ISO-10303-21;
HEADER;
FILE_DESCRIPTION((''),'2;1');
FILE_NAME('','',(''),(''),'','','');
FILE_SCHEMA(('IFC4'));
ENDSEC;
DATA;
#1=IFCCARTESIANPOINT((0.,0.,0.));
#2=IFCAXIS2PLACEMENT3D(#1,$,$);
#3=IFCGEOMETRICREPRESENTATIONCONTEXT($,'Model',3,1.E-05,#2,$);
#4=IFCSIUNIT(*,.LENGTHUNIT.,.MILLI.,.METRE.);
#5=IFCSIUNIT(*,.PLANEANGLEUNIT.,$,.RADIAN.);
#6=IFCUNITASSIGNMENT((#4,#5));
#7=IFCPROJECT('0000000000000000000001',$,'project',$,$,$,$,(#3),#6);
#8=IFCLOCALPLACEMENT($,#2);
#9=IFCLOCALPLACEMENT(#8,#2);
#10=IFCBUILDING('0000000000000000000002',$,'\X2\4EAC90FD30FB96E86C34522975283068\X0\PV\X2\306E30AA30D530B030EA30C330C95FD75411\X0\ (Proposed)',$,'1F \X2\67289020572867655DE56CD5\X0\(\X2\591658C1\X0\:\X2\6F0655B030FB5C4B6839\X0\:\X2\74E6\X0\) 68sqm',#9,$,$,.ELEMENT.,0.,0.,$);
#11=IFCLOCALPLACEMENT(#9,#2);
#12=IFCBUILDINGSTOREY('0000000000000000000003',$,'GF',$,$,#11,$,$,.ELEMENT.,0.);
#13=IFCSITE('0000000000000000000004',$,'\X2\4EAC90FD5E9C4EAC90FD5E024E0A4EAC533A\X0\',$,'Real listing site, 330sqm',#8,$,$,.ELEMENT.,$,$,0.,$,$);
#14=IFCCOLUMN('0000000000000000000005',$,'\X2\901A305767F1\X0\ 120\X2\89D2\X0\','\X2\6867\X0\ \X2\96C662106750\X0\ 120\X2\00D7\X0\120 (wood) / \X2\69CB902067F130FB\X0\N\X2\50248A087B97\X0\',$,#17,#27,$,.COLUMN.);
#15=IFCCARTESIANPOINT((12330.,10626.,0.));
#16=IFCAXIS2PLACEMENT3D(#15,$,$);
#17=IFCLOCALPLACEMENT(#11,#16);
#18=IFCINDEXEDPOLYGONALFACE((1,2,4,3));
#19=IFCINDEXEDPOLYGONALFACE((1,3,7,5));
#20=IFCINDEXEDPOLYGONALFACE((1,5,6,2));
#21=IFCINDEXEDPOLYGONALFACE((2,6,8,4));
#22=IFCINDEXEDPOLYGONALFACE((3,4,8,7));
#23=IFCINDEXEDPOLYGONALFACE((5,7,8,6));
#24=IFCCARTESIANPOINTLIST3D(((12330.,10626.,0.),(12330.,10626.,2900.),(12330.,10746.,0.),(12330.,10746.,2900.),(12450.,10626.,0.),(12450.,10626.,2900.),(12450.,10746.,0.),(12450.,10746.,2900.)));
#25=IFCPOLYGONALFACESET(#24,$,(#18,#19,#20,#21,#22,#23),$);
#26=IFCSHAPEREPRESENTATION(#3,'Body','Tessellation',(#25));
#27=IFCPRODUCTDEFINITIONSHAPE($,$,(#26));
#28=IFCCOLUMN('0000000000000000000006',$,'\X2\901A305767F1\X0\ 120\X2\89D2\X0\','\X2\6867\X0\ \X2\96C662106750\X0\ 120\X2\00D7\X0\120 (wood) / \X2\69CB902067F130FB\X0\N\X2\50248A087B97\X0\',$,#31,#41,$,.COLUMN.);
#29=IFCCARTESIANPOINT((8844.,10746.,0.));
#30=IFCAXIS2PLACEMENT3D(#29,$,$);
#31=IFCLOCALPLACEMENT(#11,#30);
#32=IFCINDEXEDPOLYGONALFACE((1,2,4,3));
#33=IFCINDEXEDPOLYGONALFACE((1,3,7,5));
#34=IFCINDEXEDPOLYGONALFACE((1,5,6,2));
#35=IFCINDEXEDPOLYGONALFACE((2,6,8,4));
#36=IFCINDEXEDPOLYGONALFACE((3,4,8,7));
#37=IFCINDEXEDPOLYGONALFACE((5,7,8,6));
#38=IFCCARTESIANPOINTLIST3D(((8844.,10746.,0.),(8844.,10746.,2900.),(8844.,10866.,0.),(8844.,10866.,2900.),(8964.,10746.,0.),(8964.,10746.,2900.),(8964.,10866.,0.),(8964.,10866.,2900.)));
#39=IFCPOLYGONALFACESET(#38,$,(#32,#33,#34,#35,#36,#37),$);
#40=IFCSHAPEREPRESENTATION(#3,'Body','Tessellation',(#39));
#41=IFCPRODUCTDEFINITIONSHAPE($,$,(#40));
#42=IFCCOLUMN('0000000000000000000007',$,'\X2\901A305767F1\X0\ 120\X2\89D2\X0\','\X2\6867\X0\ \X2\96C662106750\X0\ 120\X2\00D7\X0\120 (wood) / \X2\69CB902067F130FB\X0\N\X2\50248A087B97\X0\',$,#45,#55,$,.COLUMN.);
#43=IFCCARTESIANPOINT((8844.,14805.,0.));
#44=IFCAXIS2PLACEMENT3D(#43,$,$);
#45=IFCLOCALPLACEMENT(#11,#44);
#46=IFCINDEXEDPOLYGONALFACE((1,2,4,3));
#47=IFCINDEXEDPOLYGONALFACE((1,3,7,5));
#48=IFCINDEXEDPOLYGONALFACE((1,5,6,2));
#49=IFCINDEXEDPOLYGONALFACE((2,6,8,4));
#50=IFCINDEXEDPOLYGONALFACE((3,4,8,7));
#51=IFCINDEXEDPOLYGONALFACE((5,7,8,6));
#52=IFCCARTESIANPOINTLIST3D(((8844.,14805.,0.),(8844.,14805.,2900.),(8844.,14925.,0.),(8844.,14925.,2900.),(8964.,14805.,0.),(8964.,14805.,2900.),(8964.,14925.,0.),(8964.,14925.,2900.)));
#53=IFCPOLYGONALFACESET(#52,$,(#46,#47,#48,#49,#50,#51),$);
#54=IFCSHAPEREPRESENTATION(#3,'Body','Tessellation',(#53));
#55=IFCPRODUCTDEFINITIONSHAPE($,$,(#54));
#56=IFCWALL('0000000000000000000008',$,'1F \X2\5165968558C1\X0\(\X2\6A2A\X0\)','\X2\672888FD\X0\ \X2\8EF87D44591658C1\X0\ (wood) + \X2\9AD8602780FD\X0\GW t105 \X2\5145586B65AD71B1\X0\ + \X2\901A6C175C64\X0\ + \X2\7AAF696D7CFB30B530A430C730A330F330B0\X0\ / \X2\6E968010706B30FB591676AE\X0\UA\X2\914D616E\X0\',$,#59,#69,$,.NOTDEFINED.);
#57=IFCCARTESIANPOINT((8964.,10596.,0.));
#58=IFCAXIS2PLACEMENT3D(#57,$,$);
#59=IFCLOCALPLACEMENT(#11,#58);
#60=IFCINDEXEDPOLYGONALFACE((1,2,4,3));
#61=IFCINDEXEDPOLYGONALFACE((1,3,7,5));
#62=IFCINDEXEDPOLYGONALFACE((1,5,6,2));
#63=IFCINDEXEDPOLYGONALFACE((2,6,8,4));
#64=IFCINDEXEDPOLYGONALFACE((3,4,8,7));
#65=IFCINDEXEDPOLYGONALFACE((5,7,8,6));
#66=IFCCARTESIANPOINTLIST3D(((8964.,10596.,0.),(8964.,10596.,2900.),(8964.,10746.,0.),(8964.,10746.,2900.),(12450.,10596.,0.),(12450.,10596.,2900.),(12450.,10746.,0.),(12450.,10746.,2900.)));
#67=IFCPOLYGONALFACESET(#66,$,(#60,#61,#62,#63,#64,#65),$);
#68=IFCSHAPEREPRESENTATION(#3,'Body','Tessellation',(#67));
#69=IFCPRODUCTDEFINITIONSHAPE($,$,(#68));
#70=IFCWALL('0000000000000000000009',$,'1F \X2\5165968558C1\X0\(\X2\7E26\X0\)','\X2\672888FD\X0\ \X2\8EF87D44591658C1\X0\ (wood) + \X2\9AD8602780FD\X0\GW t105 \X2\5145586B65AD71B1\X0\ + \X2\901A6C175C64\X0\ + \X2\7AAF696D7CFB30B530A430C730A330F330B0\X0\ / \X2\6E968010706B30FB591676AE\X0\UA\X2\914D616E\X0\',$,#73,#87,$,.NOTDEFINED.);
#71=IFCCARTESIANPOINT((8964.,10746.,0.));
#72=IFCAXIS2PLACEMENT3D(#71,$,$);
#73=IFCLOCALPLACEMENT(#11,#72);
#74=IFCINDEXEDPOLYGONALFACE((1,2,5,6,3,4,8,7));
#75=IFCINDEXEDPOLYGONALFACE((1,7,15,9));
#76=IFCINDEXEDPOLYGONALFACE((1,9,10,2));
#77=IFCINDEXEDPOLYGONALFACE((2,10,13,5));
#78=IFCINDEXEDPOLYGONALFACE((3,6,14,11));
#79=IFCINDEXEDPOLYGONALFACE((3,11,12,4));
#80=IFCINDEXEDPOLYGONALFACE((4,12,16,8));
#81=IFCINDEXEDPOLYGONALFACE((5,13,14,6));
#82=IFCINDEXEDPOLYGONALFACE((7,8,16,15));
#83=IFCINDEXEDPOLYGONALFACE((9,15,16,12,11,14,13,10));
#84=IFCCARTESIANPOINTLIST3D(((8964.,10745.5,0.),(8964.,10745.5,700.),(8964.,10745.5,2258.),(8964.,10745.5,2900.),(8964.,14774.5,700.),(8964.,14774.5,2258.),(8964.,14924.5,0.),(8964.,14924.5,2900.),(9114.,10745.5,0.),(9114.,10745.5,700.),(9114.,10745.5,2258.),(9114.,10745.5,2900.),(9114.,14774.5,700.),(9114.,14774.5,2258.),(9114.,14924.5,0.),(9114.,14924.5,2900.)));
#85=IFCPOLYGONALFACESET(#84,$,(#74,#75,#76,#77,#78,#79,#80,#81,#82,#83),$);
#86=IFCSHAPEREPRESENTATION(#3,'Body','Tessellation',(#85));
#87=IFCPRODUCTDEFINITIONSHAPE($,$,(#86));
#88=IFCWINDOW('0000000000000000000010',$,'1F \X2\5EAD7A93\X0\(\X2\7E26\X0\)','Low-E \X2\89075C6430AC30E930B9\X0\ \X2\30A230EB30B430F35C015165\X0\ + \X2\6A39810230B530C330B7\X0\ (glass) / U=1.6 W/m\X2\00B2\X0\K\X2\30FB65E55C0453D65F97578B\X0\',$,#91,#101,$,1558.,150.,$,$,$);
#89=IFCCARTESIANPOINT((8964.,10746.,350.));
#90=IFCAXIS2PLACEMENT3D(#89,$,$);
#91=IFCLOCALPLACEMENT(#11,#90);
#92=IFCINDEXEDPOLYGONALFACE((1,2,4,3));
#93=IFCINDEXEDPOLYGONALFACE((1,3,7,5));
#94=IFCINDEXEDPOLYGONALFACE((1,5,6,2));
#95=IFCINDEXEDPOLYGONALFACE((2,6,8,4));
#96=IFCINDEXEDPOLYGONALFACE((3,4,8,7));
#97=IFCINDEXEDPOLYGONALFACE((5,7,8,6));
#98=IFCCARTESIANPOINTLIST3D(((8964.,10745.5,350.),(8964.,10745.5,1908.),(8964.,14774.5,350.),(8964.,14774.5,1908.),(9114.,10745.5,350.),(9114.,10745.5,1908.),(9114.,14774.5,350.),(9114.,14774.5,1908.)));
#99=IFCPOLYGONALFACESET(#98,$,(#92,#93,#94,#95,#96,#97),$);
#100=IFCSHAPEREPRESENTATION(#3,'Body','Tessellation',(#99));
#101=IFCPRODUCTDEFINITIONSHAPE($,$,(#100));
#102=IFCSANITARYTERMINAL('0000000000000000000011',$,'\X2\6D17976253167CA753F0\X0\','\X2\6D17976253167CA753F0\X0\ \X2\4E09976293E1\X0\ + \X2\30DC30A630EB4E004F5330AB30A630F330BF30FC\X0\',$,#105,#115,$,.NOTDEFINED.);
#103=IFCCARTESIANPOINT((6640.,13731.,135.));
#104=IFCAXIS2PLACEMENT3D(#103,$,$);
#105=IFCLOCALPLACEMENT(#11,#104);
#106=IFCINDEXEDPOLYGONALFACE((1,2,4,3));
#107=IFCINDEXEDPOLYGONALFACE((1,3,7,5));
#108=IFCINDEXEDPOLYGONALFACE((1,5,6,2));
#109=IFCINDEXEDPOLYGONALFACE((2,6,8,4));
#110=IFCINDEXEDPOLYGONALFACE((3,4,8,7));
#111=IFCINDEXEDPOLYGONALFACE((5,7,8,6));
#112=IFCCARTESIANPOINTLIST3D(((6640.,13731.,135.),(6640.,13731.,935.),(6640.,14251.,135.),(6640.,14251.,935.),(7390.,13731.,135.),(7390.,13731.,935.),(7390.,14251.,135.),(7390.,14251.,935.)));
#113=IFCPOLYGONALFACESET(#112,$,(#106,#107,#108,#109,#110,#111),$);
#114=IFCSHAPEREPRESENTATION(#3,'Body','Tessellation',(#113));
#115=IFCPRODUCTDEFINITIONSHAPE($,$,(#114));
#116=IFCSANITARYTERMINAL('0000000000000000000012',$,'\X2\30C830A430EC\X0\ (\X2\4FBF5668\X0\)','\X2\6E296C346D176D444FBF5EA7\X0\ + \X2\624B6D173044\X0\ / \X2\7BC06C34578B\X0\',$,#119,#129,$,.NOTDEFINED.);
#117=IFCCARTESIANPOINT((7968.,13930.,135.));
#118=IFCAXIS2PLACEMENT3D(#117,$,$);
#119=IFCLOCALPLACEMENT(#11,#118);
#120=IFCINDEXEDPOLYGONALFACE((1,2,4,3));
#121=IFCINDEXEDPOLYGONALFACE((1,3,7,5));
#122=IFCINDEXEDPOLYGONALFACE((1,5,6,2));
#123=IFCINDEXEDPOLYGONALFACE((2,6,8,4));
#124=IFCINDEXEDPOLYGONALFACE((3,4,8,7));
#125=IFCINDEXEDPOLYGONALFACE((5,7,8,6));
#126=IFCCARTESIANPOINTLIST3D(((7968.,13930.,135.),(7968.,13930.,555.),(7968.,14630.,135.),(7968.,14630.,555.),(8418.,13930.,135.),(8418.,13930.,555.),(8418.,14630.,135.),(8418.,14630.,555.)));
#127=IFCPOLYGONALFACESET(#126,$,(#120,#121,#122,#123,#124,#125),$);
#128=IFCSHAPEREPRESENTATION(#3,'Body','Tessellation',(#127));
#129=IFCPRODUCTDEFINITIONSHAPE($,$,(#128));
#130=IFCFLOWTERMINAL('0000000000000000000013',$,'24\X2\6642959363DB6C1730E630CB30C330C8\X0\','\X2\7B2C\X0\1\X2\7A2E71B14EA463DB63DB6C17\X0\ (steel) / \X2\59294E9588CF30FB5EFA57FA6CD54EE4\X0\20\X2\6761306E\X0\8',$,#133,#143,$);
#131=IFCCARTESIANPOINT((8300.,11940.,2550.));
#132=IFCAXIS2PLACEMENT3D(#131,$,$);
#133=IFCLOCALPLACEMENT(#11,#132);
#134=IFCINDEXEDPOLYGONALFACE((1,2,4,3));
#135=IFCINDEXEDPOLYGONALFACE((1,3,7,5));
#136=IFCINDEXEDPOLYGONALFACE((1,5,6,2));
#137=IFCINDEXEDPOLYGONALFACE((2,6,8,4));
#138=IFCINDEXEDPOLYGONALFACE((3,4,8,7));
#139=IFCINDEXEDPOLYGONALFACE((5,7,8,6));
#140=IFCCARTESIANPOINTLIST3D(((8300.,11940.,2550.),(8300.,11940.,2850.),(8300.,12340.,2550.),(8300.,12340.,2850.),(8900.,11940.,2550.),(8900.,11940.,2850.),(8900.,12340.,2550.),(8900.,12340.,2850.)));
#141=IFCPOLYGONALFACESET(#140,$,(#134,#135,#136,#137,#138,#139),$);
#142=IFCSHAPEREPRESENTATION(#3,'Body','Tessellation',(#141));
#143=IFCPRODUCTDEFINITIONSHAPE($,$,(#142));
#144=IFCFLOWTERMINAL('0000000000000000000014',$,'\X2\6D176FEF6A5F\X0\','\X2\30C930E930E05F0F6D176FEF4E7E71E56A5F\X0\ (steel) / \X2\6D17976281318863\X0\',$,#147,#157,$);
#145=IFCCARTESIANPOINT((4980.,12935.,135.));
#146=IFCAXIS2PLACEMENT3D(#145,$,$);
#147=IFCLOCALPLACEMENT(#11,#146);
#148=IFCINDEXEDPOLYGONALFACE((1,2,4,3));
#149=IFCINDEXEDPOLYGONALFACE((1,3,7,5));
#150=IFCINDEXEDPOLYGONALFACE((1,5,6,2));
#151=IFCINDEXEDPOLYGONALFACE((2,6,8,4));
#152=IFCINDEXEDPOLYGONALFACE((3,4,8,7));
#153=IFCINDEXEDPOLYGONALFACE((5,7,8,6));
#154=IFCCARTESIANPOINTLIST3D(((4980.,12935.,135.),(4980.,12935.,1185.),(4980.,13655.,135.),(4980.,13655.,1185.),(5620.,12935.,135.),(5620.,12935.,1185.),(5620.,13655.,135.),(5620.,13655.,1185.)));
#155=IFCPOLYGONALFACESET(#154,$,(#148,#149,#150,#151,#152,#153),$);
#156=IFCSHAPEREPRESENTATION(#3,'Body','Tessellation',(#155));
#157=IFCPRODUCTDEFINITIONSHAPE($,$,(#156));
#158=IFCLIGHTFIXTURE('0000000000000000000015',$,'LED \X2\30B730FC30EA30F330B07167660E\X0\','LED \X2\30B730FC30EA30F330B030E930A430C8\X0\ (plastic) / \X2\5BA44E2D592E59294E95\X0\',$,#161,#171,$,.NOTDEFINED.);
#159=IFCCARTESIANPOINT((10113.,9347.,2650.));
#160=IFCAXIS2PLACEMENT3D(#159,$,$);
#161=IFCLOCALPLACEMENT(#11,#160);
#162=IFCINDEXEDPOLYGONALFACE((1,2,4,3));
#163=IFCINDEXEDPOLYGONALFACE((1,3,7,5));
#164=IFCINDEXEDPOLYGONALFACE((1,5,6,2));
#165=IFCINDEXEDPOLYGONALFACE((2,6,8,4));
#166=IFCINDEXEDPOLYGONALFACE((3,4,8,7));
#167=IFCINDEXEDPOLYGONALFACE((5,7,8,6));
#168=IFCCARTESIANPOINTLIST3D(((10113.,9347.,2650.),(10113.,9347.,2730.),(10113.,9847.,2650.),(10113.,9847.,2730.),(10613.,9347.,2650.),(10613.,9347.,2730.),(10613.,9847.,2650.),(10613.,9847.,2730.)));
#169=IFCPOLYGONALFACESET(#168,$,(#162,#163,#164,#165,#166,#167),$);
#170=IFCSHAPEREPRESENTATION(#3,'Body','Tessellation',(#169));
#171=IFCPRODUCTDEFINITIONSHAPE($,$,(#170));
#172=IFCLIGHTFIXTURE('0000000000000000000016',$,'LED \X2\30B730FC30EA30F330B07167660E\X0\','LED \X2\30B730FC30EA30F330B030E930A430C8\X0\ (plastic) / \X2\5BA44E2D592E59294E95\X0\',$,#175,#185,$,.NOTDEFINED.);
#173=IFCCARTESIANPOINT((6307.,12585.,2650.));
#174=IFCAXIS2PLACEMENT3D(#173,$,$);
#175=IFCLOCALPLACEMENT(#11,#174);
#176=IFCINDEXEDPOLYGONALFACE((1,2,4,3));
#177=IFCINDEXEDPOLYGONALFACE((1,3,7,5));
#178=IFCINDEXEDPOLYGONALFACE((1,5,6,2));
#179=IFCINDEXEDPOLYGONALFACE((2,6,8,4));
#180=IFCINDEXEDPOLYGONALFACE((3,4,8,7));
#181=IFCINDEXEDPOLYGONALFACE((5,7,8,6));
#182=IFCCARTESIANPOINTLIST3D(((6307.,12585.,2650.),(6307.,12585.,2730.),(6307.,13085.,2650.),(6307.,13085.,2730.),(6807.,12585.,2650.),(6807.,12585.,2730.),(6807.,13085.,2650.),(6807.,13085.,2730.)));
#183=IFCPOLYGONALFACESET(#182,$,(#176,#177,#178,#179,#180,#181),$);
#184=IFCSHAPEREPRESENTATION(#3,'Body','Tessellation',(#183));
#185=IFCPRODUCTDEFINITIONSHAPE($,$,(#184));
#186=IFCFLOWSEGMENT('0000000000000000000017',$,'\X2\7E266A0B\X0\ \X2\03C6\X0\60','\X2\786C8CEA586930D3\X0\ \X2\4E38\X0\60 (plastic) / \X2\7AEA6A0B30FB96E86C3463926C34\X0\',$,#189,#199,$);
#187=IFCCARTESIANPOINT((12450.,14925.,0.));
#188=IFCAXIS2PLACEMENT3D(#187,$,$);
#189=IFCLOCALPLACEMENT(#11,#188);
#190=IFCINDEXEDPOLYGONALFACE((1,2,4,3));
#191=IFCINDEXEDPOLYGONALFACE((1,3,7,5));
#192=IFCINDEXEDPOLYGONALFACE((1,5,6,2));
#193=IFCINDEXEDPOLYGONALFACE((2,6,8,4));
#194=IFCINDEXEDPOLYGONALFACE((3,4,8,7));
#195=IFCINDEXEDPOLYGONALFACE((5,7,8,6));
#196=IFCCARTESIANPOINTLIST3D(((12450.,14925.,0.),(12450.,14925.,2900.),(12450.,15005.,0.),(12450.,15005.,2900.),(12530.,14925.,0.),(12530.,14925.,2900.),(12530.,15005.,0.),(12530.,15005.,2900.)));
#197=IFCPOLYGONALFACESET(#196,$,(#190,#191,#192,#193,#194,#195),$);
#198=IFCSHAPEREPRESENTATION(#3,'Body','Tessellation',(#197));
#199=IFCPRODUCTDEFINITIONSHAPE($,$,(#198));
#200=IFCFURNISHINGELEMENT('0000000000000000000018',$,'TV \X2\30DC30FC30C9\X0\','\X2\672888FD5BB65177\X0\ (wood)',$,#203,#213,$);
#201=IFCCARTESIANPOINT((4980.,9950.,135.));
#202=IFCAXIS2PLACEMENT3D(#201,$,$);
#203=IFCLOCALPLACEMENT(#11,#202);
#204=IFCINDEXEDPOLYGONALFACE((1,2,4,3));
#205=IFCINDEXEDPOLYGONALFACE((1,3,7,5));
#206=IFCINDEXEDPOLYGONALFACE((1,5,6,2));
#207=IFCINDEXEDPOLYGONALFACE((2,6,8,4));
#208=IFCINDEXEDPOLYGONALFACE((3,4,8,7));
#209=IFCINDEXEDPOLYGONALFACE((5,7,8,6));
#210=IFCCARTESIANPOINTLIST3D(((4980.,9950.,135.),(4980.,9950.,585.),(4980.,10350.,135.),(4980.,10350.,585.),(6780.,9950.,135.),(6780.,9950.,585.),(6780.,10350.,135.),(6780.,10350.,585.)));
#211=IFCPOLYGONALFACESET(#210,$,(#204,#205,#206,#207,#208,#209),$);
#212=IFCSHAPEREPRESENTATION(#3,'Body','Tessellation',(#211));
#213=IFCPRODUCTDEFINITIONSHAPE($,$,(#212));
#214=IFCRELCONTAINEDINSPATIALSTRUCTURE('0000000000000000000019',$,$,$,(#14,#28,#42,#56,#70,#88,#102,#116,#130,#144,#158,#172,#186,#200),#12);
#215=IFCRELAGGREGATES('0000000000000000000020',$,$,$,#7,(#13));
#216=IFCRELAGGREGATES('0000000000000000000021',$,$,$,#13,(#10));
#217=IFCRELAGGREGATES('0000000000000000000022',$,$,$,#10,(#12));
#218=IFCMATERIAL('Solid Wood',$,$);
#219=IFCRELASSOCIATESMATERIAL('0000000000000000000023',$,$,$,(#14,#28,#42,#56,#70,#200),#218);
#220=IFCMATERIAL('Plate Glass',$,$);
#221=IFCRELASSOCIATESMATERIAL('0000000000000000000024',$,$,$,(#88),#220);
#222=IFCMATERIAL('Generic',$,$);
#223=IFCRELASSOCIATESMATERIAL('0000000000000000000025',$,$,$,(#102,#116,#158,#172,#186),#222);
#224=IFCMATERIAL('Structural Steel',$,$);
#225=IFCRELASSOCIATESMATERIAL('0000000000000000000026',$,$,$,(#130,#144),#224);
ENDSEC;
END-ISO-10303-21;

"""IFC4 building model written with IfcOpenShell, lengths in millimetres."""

from ifc_helpers import new_model, si_unit, frame, frame_2d, origin, place, context, project, spatial, rectangle, extrude, material, element, fill, save


model = new_model("IFC4")

# Units and contexts
model_context = context("Model", 3, precision=1e-05, world=origin())
ifc_project = project(units=[si_unit("LENGTHUNIT", "METRE", prefix="MILLI"), si_unit("PLANEANGLEUNIT", "RADIAN")], contexts=[model_context])

# Site, building, storey
site_placement = place(None, origin())
site = spatial("IfcSite", under=ifc_project, at=site_placement, Name="京都府京都市上京区", ObjectType="Real listing site, 330sqm", CompositionType="ELEMENT", RefElevation=0.0)
building_placement = place(site_placement, origin())
building = spatial("IfcBuilding", under=site, at=building_placement, Name="京都・雨水利用とPVのオフグリッド志向 (Proposed)", ObjectType="1F 木造在来工法(外壁:漆喰・屋根:瓦) 68sqm", CompositionType="ELEMENT", ElevationOfRefHeight=0.0, ElevationOfTerrain=0.0)
storey_placement = place(building_placement, origin())
storey = spatial("IfcBuildingStorey", under=building, at=storey_placement, Name="GF", CompositionType="ELEMENT", Elevation=0.0)

# Columns
ifc_material_1 = material(Name="Solid Wood")
column_1_placement = place(storey_placement, frame((12330.0, 10626.0, 0.0)))
element("IfcColumn", 1, at=column_1_placement, inside=storey, material=ifc_material_1, Name="通し柱 120角", Description="桧 集成材 120×120 (wood) / 構造柱・N値計算", PredefinedType="COLUMN", context=model_context, shape_type="SweptSolid", body=[
    extrude(rectangle(XDim=120.0, YDim=120.0, at=frame_2d((60.0, 60.0))), frame((12330.0, 10626.0, 0.0)), (0.0, 0.0, 1.0), 2900.0),
])
column_2_placement = place(storey_placement, frame((8844.0, 10746.0, 0.0)))
element("IfcColumn", 2, at=column_2_placement, inside=storey, material=ifc_material_1, Name="通し柱 120角", Description="桧 集成材 120×120 (wood) / 構造柱・N値計算", PredefinedType="COLUMN", context=model_context, shape_type="SweptSolid", body=[
    extrude(rectangle(XDim=120.0, YDim=120.0, at=frame_2d((60.0, 60.0))), frame((8844.0, 10746.0, 0.0)), (0.0, 0.0, 1.0), 2900.0),
])
column_3_placement = place(storey_placement, frame((8844.0, 14805.0, 0.0)))
element("IfcColumn", 3, at=column_3_placement, inside=storey, material=ifc_material_1, Name="通し柱 120角", Description="桧 集成材 120×120 (wood) / 構造柱・N値計算", PredefinedType="COLUMN", context=model_context, shape_type="SweptSolid", body=[
    extrude(rectangle(XDim=120.0, YDim=120.0, at=frame_2d((60.0, 60.0))), frame((8844.0, 14805.0, 0.0)), (0.0, 0.0, 1.0), 2900.0),
])

# Wall
wall_1_placement = place(storey_placement, frame((8964.0, 10596.0, 0.0)))
element("IfcWall", 4, at=wall_1_placement, inside=storey, material=ifc_material_1, Name="1F 入隅壁(横)", Description="木製 軸組外壁 (wood) + 高性能GW t105 充填断熱 + 通気層 + 窯業系サイディング / 準耐火・外皮UA配慮", PredefinedType="NOTDEFINED", context=model_context, shape_type="SweptSolid", body=[
    extrude(rectangle(XDim=3486.0, YDim=150.0, at=frame_2d((1743.0, 75.0))), frame((8964.0, 10596.0, 0.0)), (0.0, 0.0, 1.0), 2900.0),
])

# Wall, opening, window
wall_2_placement = place(storey_placement, frame((8964.0, 10746.0, 0.0)))
wall_2 = element("IfcWall", 5, at=wall_2_placement, inside=storey, material=ifc_material_1, Name="1F 入隅壁(縦)", Description="木製 軸組外壁 (wood) + 高性能GW t105 充填断熱 + 通気層 + 窯業系サイディング / 準耐火・外皮UA配慮", PredefinedType="NOTDEFINED", context=model_context, shape_type="SweptSolid", body=[
    extrude(rectangle(XDim=150.0, YDim=4179.0, at=frame_2d((75.0, 2089.0))), frame((8964.0, 10746.0, 0.0)), (0.0, 0.0, 1.0), 2900.0),
])
opening_placement = place(storey_placement, frame((8964.0, 10746.0, 350.0)))
opening = element("IfcOpeningElement", 6, at=opening_placement, cuts=wall_2, PredefinedType="NOTDEFINED", context=model_context, shape_type="SweptSolid", body=[
    extrude(rectangle(XDim=150.0, YDim=4029.0, at=frame_2d((75.0, 2014.0))), frame((8964.0, 10746.0, 350.0)), (0.0, 0.0, 1.0), 1558.0),
])
ifc_material_2 = material(Name="Plate Glass")
window_placement = place(storey_placement, frame((8964.0, 10746.0, 350.0)))
window = element("IfcWindow", 7, at=window_placement, inside=storey, material=ifc_material_2, Name="1F 庭窓(縦)", Description="Low-E 複層ガラス アルゴン封入 + 樹脂サッシ (glass) / U=1.6 W/m²K・日射取得型", OverallHeight=1558.0, OverallWidth=150.0, context=model_context, shape_type="SweptSolid", body=[
    extrude(rectangle(XDim=150.0, YDim=4029.0, at=frame_2d((75.0, 2014.0))), frame((8964.0, 10746.0, 350.0)), (0.0, 0.0, 1.0), 1558.0),
])
fill(opening, window)

# Sanitary terminals
ifc_material_3 = material(Name="Generic")
sanitary_terminal_1_placement = place(storey_placement, frame((6640.0, 13731.0, 135.0)))
element("IfcSanitaryTerminal", 8, at=sanitary_terminal_1_placement, inside=storey, material=ifc_material_3, Name="洗面化粧台", Description="洗面化粧台 三面鏡 + ボウル一体カウンター", PredefinedType="NOTDEFINED", context=model_context, shape_type="SweptSolid", body=[
    extrude(rectangle(XDim=750.0, YDim=520.0, at=frame_2d((375.0, 260.0))), frame((6640.0, 13731.0, 135.0)), (0.0, 0.0, 1.0), 800.0),
])
sanitary_terminal_2_placement = place(storey_placement, frame((7968.0, 13930.0, 135.0)))
element("IfcSanitaryTerminal", 9, at=sanitary_terminal_2_placement, inside=storey, material=ifc_material_3, Name="トイレ (便器)", Description="温水洗浄便座 + 手洗い / 節水型", PredefinedType="NOTDEFINED", context=model_context, shape_type="SweptSolid", body=[
    extrude(rectangle(XDim=450.0, YDim=700.0, at=frame_2d((225.0, 350.0))), frame((7968.0, 13930.0, 135.0)), (0.0, 0.0, 1.0), 420.0),
])

# Flow terminals
ifc_material_4 = material(Name="Structural Steel")
flow_terminal_1_placement = place(storey_placement, frame((8300.0, 11940.0, 2550.0)))
element("IfcFlowTerminal", 10, at=flow_terminal_1_placement, inside=storey, material=ifc_material_4, Name="24時間換気ユニット", Description="第1種熱交換換気 (steel) / 天井裏・建基法令20条の8", context=model_context, shape_type="SweptSolid", body=[
    extrude(rectangle(XDim=600.0, YDim=400.0, at=frame_2d((300.0, 200.0))), frame((8300.0, 11940.0, 2550.0)), (0.0, 0.0, 1.0), 300.0),
])
flow_terminal_2_placement = place(storey_placement, frame((4980.0, 12935.0, 135.0)))
element("IfcFlowTerminal", 11, at=flow_terminal_2_placement, inside=storey, material=ifc_material_4, Name="洗濯機", Description="ドラム式洗濯乾燥機 (steel) / 洗面脱衣", context=model_context, shape_type="SweptSolid", body=[
    extrude(rectangle(XDim=640.0, YDim=720.0, at=frame_2d((320.0, 360.0))), frame((4980.0, 12935.0, 135.0)), (0.0, 0.0, 1.0), 1050.0),
])

# Light fixtures
light_fixture_1_placement = place(storey_placement, frame((10113.0, 9347.0, 2650.0)))
element("IfcLightFixture", 12, at=light_fixture_1_placement, inside=storey, material=ifc_material_3, Name="LED シーリング照明", Description="LED シーリングライト (plastic) / 室中央天井", PredefinedType="NOTDEFINED", context=model_context, shape_type="SweptSolid", body=[
    extrude(rectangle(XDim=500.0, YDim=500.0, at=frame_2d((250.0, 250.0))), frame((10113.0, 9347.0, 2650.0)), (0.0, 0.0, 1.0), 80.0),
])
light_fixture_2_placement = place(storey_placement, frame((6307.0, 12585.0, 2650.0)))
element("IfcLightFixture", 13, at=light_fixture_2_placement, inside=storey, material=ifc_material_3, Name="LED シーリング照明", Description="LED シーリングライト (plastic) / 室中央天井", PredefinedType="NOTDEFINED", context=model_context, shape_type="SweptSolid", body=[
    extrude(rectangle(XDim=500.0, YDim=500.0, at=frame_2d((250.0, 250.0))), frame((6307.0, 12585.0, 2650.0)), (0.0, 0.0, 1.0), 80.0),
])

# Flow segment
flow_segment_placement = place(storey_placement, frame((12450.0, 14925.0, 0.0)))
element("IfcFlowSegment", 14, at=flow_segment_placement, inside=storey, material=ifc_material_3, Name="縦樋 φ60", Description="硬質塩ビ 丸60 (plastic) / 竪樋・雨水排水", context=model_context, shape_type="SweptSolid", body=[
    extrude(rectangle(XDim=80.0, YDim=80.0, at=frame_2d((40.0, 40.0))), frame((12450.0, 14925.0, 0.0)), (0.0, 0.0, 1.0), 2900.0),
])

# Furnishing element
furnishing_placement = place(storey_placement, frame((4980.0, 9950.0, 135.0)))
element("IfcFurnishingElement", 15, at=furnishing_placement, inside=storey, material=ifc_material_1, Name="TV ボード", Description="木製家具 (wood)", context=model_context, shape_type="SweptSolid", body=[
    extrude(rectangle(XDim=1800.0, YDim=400.0, at=frame_2d((900.0, 200.0))), frame((4980.0, 9950.0, 135.0)), (0.0, 0.0, 1.0), 450.0),
])

save(model, "model.ifc")
